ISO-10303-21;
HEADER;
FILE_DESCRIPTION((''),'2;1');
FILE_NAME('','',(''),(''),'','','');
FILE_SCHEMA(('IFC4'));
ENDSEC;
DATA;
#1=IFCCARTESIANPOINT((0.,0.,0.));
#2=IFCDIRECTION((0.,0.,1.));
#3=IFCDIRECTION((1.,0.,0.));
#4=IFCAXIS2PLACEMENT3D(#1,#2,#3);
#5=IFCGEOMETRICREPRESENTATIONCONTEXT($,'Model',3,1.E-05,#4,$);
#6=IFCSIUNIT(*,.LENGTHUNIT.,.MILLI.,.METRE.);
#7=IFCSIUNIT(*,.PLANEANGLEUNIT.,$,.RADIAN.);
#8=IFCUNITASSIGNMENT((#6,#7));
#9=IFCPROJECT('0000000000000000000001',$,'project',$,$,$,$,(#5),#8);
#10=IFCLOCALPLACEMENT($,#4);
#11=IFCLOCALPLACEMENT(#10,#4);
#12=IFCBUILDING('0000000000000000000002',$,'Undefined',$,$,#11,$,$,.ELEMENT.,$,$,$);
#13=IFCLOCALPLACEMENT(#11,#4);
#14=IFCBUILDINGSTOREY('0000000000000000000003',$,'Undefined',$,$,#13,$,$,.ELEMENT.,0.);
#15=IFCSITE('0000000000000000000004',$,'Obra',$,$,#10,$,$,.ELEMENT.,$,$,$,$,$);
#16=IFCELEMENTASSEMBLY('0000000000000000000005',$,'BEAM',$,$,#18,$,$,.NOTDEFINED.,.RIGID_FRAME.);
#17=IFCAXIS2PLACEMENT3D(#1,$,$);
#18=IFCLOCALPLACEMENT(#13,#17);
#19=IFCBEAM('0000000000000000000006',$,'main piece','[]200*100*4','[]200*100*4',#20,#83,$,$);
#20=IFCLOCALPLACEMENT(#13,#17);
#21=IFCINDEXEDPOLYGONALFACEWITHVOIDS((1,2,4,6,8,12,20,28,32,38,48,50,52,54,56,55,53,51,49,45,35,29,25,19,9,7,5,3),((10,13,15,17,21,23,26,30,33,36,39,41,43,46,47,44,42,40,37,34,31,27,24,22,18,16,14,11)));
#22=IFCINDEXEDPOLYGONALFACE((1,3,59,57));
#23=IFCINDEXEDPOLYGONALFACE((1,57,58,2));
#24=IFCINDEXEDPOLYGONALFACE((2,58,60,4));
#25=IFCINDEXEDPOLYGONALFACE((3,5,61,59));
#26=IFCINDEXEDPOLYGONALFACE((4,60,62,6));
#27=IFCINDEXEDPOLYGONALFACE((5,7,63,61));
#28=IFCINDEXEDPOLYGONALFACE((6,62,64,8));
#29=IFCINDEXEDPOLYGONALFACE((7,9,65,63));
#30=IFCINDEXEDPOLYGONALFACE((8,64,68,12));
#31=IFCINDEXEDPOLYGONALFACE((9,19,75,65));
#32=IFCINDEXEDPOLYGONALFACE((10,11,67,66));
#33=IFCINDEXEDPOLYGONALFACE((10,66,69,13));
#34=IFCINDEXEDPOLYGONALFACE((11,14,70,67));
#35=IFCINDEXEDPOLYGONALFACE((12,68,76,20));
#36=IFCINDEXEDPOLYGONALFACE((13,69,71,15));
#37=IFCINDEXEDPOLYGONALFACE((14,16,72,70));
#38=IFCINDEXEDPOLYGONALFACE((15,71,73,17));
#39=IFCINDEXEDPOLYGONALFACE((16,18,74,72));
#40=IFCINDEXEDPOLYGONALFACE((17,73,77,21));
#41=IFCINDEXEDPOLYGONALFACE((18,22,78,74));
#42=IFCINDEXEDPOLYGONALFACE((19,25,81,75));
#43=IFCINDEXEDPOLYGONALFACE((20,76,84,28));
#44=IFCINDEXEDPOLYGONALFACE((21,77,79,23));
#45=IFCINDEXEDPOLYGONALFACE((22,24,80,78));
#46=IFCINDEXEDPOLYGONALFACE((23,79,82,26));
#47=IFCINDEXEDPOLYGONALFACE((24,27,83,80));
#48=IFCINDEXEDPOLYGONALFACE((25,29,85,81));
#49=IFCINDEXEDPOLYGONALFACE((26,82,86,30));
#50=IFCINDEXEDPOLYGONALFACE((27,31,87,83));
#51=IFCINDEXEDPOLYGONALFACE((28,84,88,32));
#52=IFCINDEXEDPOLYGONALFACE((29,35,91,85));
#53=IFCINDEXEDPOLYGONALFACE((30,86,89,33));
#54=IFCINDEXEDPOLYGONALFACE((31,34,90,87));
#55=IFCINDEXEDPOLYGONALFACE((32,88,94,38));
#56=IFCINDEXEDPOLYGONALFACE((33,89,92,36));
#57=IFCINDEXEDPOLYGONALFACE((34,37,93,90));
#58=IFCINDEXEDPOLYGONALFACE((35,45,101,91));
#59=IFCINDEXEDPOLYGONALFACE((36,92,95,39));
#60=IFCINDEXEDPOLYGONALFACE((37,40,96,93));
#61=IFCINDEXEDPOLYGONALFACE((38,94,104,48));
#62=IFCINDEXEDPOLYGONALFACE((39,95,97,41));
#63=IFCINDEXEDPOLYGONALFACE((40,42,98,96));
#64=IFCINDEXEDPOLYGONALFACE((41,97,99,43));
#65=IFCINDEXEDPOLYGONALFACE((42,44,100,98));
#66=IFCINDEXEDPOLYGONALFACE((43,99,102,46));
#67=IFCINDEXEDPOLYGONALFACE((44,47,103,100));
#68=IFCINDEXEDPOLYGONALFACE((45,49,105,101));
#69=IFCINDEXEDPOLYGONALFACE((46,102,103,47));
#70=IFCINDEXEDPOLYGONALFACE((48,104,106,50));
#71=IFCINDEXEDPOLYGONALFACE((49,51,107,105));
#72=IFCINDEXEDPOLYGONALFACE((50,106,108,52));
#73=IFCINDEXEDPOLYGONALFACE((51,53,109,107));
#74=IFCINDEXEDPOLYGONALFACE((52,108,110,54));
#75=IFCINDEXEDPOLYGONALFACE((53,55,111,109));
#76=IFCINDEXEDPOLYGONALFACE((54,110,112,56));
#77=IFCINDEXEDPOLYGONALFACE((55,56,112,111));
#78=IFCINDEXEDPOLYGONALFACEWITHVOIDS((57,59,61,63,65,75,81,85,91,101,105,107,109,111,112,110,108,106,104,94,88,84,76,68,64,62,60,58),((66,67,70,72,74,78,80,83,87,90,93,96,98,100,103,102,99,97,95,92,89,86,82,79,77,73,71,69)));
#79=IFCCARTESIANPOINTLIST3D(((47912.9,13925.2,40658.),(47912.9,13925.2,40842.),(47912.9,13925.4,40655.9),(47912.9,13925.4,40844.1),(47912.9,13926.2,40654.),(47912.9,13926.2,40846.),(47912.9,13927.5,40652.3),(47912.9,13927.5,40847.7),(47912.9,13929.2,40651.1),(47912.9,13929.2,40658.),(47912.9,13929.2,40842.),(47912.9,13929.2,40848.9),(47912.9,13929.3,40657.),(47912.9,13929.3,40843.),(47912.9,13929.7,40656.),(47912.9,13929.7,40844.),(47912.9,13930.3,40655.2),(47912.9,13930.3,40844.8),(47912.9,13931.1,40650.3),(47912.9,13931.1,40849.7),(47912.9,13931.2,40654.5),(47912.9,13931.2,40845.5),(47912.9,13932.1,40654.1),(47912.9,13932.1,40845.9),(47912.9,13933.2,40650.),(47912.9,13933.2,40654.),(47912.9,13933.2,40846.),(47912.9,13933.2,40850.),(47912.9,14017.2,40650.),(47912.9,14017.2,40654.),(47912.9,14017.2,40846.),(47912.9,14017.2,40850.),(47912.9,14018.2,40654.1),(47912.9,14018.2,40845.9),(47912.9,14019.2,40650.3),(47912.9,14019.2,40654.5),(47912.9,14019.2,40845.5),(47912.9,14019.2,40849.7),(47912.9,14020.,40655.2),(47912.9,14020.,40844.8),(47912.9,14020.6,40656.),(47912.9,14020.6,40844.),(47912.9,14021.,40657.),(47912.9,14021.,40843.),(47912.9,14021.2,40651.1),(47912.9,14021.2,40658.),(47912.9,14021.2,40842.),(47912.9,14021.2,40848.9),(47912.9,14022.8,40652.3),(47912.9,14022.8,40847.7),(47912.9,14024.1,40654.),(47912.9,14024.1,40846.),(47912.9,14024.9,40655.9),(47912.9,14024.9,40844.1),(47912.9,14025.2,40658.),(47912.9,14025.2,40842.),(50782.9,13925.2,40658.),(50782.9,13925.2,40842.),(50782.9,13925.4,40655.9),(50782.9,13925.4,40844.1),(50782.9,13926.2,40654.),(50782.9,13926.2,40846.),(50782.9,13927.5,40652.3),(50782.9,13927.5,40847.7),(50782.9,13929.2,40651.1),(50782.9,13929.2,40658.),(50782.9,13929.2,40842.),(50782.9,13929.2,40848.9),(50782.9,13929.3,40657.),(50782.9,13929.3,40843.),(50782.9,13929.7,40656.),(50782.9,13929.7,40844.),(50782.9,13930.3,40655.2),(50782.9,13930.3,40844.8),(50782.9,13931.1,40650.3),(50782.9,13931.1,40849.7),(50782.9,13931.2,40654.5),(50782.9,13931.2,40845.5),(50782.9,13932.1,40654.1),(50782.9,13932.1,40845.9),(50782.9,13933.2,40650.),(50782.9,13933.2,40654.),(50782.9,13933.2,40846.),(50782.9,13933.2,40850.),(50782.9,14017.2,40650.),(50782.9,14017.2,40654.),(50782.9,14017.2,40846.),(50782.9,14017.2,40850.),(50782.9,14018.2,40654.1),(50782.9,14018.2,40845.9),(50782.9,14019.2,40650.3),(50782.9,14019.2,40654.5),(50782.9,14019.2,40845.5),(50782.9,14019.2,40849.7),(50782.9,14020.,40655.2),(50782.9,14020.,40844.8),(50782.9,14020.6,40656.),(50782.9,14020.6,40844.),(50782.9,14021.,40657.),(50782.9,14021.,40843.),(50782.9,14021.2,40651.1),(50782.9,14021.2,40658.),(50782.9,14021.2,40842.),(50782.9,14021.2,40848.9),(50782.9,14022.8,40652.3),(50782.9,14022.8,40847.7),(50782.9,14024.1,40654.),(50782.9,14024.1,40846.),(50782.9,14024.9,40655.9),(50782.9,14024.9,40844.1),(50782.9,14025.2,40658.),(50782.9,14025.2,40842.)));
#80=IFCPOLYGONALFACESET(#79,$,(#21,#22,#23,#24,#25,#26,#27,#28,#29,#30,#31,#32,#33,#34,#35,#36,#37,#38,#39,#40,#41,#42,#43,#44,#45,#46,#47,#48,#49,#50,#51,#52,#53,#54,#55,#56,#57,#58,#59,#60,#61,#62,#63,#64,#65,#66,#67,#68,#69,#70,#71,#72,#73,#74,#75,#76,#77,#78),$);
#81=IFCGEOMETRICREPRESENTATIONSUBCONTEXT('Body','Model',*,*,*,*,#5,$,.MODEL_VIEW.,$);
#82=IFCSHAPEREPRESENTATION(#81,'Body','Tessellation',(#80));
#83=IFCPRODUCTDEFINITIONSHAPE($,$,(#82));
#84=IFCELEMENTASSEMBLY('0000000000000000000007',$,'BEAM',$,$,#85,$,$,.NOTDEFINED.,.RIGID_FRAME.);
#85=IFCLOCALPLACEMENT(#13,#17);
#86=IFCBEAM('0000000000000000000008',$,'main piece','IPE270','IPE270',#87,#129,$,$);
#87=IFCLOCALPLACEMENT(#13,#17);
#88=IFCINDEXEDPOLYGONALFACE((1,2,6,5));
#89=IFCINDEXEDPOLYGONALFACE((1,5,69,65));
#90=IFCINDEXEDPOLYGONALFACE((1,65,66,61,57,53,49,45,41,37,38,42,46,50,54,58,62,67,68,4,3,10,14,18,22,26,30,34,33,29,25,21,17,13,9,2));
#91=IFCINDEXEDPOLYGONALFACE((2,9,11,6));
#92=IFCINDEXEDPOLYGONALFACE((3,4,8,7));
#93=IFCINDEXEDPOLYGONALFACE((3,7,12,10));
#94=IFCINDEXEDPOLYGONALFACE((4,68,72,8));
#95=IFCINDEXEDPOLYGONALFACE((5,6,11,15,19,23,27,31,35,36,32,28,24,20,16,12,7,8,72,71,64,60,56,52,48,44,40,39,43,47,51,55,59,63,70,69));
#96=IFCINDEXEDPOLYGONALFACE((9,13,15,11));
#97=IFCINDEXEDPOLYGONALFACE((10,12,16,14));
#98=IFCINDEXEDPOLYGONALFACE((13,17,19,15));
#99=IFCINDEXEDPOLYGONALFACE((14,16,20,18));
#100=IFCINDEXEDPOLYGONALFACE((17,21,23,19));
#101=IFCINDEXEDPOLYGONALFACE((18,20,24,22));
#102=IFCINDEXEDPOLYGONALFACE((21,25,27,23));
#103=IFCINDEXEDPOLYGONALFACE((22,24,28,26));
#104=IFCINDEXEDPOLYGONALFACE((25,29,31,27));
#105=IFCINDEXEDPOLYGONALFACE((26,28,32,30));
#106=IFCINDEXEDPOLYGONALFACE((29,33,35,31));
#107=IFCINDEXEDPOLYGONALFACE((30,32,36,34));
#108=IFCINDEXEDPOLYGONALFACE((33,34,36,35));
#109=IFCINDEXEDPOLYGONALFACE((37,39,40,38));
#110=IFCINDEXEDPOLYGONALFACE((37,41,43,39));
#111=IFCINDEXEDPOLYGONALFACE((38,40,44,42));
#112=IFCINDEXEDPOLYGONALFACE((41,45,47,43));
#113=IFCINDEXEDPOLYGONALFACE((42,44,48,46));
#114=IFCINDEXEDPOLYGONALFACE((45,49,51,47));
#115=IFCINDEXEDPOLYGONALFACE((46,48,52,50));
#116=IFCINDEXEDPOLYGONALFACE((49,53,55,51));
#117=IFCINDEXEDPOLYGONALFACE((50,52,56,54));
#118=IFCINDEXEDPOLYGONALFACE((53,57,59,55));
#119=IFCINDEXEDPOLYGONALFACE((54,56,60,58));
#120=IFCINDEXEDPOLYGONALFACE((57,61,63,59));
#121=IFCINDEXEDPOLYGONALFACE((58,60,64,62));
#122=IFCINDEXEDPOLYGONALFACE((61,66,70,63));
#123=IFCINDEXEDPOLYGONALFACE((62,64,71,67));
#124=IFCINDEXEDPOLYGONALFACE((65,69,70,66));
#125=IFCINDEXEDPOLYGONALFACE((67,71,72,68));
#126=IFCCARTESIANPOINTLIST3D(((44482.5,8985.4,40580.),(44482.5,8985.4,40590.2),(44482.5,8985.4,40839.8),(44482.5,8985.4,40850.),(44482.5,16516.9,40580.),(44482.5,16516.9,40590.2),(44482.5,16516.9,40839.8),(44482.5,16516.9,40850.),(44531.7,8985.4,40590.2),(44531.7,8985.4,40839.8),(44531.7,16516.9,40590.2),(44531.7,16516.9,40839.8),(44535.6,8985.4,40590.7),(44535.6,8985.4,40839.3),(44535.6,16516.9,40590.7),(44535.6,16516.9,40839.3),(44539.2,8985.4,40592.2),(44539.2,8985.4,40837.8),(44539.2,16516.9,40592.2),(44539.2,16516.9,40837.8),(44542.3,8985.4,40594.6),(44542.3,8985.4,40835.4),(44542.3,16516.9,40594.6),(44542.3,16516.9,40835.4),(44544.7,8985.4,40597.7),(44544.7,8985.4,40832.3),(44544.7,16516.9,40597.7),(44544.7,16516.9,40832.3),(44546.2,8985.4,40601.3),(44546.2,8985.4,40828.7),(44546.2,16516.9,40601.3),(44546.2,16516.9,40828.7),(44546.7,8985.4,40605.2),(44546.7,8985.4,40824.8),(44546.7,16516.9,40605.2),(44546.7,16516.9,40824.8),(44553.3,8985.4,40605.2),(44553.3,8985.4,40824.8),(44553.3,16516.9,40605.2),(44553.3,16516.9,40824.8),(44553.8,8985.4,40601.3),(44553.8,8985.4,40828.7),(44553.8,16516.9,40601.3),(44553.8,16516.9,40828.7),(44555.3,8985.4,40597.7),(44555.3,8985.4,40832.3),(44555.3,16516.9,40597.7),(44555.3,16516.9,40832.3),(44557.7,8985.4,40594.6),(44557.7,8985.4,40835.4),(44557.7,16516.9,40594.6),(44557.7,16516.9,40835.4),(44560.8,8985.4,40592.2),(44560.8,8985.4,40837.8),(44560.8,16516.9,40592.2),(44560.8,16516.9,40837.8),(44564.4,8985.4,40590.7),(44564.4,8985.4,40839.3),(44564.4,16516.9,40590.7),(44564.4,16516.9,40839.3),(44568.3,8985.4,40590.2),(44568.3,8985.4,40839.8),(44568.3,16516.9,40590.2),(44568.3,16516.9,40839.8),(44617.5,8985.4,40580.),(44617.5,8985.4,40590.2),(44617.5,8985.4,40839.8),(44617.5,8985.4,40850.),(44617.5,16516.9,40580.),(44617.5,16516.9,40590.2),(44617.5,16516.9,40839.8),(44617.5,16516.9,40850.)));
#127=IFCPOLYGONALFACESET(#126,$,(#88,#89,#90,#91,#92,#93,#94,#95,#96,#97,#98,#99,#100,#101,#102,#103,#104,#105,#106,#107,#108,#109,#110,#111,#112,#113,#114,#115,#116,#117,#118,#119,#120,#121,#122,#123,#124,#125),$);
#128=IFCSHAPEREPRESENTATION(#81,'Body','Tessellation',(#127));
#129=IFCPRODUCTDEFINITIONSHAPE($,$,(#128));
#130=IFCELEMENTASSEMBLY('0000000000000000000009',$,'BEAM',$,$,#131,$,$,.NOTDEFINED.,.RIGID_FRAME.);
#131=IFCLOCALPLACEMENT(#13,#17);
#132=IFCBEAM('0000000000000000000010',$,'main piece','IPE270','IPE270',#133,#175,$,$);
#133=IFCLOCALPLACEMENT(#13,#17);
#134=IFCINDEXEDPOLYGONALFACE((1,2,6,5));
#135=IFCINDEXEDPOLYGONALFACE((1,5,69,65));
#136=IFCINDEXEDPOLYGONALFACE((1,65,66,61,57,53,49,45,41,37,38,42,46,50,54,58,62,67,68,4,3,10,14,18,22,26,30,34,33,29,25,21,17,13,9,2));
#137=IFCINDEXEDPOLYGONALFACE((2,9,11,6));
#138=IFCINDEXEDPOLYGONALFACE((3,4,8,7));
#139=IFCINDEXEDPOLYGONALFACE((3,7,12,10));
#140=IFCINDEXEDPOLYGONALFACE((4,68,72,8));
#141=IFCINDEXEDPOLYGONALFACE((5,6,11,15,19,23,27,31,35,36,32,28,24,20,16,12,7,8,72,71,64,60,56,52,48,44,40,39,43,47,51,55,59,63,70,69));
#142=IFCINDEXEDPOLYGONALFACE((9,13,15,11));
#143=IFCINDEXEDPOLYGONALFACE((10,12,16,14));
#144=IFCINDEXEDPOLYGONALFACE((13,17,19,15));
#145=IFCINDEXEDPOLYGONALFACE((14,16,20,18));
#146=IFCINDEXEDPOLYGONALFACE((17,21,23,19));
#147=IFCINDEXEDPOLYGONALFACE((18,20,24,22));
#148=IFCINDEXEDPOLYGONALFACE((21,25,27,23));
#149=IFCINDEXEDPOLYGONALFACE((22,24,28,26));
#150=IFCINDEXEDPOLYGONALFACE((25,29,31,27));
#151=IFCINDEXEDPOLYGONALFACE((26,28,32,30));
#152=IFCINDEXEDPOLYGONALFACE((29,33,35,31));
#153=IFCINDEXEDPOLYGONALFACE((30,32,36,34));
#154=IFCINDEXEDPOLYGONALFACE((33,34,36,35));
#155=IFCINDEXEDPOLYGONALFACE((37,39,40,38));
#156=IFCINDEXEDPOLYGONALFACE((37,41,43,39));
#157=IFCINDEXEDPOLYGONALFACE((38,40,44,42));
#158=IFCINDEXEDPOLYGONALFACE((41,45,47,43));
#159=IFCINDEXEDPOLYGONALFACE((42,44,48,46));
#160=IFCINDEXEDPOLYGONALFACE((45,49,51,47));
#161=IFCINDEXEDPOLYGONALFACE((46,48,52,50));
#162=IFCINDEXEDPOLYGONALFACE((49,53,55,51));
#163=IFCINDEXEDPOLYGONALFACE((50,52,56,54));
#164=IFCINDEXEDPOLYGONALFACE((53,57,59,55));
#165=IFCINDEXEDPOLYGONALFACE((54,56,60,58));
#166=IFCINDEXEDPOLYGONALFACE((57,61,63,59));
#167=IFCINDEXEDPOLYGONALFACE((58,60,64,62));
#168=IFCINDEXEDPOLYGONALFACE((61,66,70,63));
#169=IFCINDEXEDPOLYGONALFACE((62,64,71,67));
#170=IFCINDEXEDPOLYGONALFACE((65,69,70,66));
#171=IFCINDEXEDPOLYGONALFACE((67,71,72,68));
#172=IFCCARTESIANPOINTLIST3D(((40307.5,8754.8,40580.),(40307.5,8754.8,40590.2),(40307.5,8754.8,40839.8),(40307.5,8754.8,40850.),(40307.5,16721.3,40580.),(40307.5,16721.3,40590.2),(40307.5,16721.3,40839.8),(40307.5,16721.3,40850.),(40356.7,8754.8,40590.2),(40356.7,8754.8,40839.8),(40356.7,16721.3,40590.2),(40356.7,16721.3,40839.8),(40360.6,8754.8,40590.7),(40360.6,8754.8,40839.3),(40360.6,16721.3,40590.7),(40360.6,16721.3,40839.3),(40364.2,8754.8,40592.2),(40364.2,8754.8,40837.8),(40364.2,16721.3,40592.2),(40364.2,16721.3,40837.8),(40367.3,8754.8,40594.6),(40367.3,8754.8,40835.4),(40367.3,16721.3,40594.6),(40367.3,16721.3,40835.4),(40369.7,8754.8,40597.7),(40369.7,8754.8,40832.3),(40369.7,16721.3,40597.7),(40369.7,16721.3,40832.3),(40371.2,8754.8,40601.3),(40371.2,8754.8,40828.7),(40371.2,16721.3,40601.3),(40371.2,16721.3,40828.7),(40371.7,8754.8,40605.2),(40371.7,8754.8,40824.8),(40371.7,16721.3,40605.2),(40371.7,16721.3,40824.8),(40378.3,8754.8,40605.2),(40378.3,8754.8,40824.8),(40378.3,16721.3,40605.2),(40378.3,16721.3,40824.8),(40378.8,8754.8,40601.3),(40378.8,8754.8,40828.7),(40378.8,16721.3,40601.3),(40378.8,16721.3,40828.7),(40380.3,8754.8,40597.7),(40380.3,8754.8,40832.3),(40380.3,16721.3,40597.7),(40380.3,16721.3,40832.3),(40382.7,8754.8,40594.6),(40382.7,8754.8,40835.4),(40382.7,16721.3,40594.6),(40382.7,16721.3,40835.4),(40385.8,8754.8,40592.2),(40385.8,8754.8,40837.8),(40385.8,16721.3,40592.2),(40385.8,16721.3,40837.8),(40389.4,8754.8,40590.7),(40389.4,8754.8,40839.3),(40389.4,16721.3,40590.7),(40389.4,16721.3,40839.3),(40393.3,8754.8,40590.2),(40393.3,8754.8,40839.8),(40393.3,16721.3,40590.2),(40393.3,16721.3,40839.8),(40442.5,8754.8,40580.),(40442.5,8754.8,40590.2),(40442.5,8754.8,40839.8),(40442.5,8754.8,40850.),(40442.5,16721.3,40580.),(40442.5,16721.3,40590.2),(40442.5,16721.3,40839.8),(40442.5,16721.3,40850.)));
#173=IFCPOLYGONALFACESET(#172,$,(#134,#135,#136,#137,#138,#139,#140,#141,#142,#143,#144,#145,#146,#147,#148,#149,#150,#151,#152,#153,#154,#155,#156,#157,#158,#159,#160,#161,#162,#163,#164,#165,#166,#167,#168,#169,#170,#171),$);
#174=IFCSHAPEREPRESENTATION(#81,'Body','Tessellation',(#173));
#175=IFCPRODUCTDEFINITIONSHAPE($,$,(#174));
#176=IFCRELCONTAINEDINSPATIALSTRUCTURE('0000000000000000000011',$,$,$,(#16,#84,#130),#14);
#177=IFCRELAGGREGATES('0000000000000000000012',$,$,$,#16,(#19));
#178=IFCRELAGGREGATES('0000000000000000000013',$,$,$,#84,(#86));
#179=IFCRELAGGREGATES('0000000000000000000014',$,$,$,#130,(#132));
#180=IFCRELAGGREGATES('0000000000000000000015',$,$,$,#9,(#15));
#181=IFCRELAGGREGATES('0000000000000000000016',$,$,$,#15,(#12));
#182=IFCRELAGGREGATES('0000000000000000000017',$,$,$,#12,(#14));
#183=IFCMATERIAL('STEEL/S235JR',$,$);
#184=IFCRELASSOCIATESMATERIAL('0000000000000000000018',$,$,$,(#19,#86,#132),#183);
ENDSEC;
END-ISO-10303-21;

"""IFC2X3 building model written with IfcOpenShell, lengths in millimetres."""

from ifc_helpers import new_model, si_unit, frame, origin_with_axes, origin_2d_with_axis, place, context, subcontext, project, spatial, hollow_rectangle, i_section, extrude, material, element, aggregate, save


model = new_model("IFC2X3")

# Units and contexts
model_context = context("Model", 3, precision=1e-05, world=origin_with_axes())
body_context = subcontext(model_context, "Body", "Model", "MODEL_VIEW")
ifc_project = project(units=[si_unit("LENGTHUNIT", "METRE", prefix="MILLI"), si_unit("PLANEANGLEUNIT", "RADIAN")], contexts=[model_context])

# Site, building, storey
site_placement = place(None, origin_with_axes())
site = spatial("IfcSite", under=ifc_project, at=site_placement, Name="Obra", CompositionType="ELEMENT")
building_placement = place(site_placement, origin_with_axes())
building = spatial("IfcBuilding", under=site, at=building_placement, Name="Undefined", CompositionType="ELEMENT")
storey_placement = place(building_placement, origin_with_axes())
storey = spatial("IfcBuildingStorey", under=building, at=storey_placement, Name="Undefined", CompositionType="ELEMENT", Elevation=0.0)

# Element assemblies, beams
ifc_material_1 = material(Name="STEEL/S235JR")
assembly_1_placement = place(storey_placement, origin_with_axes())
assembly_1 = element("IfcElementAssembly", 1, at=assembly_1_placement, inside=storey, Name="BEAM", AssemblyPlace="NOTDEFINED", PredefinedType="RIGID_FRAME")
beam_1_placement = place(assembly_1_placement, frame((47912.9, 13975.2, 40750.0), z_axis=(0.0, 0.0, 1.0), x_axis=(1.0, 0.0, 0.0)))
beam_1 = element("IfcBeam", 2, at=beam_1_placement, material=ifc_material_1, Name="main piece", Description="[]200*100*4", ObjectType="[]200*100*4", context=body_context, shape_type="SweptSolid", body=[
    extrude(hollow_rectangle(XDim=100.0, YDim=200.0, WallThickness=4.0, InnerFilletRadius=4.0, OuterFilletRadius=8.0, at=origin_2d_with_axis()), frame((2870.0, 0.0, 0.0), z_axis=(-1.0, 0.0, 0.0), x_axis=(0.0, -1.0, 0.0)), (0.0, 0.0, 1.0), 2870.0),
])
aggregate(assembly_1, [beam_1])
assembly_2_placement = place(storey_placement, origin_with_axes())
assembly_2 = element("IfcElementAssembly", 3, at=assembly_2_placement, inside=storey, Name="BEAM", AssemblyPlace="NOTDEFINED", PredefinedType="RIGID_FRAME")
beam_2_placement = place(assembly_2_placement, frame((44550.0, 16516.9, 40715.0), z_axis=(0.0, 0.0, 1.0), x_axis=(0.0, -1.0, 0.0)))
beam_2 = element("IfcBeam", 4, at=beam_2_placement, material=ifc_material_1, Name="main piece", Description="IPE270", ObjectType="IPE270", context=body_context, shape_type="SweptSolid", body=[
    extrude(i_section(OverallWidth=135.0, OverallDepth=270.0, WebThickness=6.6, FlangeThickness=10.2, FilletRadius=15.0, at=origin_2d_with_axis()), frame((7531.5, 0.0, 0.0), z_axis=(-1.0, 0.0, 0.0), x_axis=(0.0, -1.0, 0.0)), (0.0, 0.0, 1.0), 7531.5),
])
aggregate(assembly_2, [beam_2])
assembly_3_placement = place(storey_placement, origin_with_axes())
assembly_3 = element("IfcElementAssembly", 5, at=assembly_3_placement, inside=storey, Name="BEAM", AssemblyPlace="NOTDEFINED", PredefinedType="RIGID_FRAME")
beam_3_placement = place(assembly_3_placement, frame((40375.0, 16721.3, 40715.0), z_axis=(0.0, 0.0, 1.0), x_axis=(0.0, -1.0, 0.0)))
beam_3 = element("IfcBeam", 6, at=beam_3_placement, material=ifc_material_1, Name="main piece", Description="IPE270", ObjectType="IPE270", context=body_context, shape_type="SweptSolid", body=[
    extrude(i_section(OverallWidth=135.0, OverallDepth=270.0, WebThickness=6.6, FlangeThickness=10.2, FilletRadius=15.0, at=origin_2d_with_axis()), frame((7966.5, 0.0, 0.0), z_axis=(-1.0, 0.0, 0.0), x_axis=(0.0, -1.0, 0.0)), (0.0, 0.0, 1.0), 7966.5),
])
aggregate(assembly_3, [beam_3])

save(model, "model.ifc")
